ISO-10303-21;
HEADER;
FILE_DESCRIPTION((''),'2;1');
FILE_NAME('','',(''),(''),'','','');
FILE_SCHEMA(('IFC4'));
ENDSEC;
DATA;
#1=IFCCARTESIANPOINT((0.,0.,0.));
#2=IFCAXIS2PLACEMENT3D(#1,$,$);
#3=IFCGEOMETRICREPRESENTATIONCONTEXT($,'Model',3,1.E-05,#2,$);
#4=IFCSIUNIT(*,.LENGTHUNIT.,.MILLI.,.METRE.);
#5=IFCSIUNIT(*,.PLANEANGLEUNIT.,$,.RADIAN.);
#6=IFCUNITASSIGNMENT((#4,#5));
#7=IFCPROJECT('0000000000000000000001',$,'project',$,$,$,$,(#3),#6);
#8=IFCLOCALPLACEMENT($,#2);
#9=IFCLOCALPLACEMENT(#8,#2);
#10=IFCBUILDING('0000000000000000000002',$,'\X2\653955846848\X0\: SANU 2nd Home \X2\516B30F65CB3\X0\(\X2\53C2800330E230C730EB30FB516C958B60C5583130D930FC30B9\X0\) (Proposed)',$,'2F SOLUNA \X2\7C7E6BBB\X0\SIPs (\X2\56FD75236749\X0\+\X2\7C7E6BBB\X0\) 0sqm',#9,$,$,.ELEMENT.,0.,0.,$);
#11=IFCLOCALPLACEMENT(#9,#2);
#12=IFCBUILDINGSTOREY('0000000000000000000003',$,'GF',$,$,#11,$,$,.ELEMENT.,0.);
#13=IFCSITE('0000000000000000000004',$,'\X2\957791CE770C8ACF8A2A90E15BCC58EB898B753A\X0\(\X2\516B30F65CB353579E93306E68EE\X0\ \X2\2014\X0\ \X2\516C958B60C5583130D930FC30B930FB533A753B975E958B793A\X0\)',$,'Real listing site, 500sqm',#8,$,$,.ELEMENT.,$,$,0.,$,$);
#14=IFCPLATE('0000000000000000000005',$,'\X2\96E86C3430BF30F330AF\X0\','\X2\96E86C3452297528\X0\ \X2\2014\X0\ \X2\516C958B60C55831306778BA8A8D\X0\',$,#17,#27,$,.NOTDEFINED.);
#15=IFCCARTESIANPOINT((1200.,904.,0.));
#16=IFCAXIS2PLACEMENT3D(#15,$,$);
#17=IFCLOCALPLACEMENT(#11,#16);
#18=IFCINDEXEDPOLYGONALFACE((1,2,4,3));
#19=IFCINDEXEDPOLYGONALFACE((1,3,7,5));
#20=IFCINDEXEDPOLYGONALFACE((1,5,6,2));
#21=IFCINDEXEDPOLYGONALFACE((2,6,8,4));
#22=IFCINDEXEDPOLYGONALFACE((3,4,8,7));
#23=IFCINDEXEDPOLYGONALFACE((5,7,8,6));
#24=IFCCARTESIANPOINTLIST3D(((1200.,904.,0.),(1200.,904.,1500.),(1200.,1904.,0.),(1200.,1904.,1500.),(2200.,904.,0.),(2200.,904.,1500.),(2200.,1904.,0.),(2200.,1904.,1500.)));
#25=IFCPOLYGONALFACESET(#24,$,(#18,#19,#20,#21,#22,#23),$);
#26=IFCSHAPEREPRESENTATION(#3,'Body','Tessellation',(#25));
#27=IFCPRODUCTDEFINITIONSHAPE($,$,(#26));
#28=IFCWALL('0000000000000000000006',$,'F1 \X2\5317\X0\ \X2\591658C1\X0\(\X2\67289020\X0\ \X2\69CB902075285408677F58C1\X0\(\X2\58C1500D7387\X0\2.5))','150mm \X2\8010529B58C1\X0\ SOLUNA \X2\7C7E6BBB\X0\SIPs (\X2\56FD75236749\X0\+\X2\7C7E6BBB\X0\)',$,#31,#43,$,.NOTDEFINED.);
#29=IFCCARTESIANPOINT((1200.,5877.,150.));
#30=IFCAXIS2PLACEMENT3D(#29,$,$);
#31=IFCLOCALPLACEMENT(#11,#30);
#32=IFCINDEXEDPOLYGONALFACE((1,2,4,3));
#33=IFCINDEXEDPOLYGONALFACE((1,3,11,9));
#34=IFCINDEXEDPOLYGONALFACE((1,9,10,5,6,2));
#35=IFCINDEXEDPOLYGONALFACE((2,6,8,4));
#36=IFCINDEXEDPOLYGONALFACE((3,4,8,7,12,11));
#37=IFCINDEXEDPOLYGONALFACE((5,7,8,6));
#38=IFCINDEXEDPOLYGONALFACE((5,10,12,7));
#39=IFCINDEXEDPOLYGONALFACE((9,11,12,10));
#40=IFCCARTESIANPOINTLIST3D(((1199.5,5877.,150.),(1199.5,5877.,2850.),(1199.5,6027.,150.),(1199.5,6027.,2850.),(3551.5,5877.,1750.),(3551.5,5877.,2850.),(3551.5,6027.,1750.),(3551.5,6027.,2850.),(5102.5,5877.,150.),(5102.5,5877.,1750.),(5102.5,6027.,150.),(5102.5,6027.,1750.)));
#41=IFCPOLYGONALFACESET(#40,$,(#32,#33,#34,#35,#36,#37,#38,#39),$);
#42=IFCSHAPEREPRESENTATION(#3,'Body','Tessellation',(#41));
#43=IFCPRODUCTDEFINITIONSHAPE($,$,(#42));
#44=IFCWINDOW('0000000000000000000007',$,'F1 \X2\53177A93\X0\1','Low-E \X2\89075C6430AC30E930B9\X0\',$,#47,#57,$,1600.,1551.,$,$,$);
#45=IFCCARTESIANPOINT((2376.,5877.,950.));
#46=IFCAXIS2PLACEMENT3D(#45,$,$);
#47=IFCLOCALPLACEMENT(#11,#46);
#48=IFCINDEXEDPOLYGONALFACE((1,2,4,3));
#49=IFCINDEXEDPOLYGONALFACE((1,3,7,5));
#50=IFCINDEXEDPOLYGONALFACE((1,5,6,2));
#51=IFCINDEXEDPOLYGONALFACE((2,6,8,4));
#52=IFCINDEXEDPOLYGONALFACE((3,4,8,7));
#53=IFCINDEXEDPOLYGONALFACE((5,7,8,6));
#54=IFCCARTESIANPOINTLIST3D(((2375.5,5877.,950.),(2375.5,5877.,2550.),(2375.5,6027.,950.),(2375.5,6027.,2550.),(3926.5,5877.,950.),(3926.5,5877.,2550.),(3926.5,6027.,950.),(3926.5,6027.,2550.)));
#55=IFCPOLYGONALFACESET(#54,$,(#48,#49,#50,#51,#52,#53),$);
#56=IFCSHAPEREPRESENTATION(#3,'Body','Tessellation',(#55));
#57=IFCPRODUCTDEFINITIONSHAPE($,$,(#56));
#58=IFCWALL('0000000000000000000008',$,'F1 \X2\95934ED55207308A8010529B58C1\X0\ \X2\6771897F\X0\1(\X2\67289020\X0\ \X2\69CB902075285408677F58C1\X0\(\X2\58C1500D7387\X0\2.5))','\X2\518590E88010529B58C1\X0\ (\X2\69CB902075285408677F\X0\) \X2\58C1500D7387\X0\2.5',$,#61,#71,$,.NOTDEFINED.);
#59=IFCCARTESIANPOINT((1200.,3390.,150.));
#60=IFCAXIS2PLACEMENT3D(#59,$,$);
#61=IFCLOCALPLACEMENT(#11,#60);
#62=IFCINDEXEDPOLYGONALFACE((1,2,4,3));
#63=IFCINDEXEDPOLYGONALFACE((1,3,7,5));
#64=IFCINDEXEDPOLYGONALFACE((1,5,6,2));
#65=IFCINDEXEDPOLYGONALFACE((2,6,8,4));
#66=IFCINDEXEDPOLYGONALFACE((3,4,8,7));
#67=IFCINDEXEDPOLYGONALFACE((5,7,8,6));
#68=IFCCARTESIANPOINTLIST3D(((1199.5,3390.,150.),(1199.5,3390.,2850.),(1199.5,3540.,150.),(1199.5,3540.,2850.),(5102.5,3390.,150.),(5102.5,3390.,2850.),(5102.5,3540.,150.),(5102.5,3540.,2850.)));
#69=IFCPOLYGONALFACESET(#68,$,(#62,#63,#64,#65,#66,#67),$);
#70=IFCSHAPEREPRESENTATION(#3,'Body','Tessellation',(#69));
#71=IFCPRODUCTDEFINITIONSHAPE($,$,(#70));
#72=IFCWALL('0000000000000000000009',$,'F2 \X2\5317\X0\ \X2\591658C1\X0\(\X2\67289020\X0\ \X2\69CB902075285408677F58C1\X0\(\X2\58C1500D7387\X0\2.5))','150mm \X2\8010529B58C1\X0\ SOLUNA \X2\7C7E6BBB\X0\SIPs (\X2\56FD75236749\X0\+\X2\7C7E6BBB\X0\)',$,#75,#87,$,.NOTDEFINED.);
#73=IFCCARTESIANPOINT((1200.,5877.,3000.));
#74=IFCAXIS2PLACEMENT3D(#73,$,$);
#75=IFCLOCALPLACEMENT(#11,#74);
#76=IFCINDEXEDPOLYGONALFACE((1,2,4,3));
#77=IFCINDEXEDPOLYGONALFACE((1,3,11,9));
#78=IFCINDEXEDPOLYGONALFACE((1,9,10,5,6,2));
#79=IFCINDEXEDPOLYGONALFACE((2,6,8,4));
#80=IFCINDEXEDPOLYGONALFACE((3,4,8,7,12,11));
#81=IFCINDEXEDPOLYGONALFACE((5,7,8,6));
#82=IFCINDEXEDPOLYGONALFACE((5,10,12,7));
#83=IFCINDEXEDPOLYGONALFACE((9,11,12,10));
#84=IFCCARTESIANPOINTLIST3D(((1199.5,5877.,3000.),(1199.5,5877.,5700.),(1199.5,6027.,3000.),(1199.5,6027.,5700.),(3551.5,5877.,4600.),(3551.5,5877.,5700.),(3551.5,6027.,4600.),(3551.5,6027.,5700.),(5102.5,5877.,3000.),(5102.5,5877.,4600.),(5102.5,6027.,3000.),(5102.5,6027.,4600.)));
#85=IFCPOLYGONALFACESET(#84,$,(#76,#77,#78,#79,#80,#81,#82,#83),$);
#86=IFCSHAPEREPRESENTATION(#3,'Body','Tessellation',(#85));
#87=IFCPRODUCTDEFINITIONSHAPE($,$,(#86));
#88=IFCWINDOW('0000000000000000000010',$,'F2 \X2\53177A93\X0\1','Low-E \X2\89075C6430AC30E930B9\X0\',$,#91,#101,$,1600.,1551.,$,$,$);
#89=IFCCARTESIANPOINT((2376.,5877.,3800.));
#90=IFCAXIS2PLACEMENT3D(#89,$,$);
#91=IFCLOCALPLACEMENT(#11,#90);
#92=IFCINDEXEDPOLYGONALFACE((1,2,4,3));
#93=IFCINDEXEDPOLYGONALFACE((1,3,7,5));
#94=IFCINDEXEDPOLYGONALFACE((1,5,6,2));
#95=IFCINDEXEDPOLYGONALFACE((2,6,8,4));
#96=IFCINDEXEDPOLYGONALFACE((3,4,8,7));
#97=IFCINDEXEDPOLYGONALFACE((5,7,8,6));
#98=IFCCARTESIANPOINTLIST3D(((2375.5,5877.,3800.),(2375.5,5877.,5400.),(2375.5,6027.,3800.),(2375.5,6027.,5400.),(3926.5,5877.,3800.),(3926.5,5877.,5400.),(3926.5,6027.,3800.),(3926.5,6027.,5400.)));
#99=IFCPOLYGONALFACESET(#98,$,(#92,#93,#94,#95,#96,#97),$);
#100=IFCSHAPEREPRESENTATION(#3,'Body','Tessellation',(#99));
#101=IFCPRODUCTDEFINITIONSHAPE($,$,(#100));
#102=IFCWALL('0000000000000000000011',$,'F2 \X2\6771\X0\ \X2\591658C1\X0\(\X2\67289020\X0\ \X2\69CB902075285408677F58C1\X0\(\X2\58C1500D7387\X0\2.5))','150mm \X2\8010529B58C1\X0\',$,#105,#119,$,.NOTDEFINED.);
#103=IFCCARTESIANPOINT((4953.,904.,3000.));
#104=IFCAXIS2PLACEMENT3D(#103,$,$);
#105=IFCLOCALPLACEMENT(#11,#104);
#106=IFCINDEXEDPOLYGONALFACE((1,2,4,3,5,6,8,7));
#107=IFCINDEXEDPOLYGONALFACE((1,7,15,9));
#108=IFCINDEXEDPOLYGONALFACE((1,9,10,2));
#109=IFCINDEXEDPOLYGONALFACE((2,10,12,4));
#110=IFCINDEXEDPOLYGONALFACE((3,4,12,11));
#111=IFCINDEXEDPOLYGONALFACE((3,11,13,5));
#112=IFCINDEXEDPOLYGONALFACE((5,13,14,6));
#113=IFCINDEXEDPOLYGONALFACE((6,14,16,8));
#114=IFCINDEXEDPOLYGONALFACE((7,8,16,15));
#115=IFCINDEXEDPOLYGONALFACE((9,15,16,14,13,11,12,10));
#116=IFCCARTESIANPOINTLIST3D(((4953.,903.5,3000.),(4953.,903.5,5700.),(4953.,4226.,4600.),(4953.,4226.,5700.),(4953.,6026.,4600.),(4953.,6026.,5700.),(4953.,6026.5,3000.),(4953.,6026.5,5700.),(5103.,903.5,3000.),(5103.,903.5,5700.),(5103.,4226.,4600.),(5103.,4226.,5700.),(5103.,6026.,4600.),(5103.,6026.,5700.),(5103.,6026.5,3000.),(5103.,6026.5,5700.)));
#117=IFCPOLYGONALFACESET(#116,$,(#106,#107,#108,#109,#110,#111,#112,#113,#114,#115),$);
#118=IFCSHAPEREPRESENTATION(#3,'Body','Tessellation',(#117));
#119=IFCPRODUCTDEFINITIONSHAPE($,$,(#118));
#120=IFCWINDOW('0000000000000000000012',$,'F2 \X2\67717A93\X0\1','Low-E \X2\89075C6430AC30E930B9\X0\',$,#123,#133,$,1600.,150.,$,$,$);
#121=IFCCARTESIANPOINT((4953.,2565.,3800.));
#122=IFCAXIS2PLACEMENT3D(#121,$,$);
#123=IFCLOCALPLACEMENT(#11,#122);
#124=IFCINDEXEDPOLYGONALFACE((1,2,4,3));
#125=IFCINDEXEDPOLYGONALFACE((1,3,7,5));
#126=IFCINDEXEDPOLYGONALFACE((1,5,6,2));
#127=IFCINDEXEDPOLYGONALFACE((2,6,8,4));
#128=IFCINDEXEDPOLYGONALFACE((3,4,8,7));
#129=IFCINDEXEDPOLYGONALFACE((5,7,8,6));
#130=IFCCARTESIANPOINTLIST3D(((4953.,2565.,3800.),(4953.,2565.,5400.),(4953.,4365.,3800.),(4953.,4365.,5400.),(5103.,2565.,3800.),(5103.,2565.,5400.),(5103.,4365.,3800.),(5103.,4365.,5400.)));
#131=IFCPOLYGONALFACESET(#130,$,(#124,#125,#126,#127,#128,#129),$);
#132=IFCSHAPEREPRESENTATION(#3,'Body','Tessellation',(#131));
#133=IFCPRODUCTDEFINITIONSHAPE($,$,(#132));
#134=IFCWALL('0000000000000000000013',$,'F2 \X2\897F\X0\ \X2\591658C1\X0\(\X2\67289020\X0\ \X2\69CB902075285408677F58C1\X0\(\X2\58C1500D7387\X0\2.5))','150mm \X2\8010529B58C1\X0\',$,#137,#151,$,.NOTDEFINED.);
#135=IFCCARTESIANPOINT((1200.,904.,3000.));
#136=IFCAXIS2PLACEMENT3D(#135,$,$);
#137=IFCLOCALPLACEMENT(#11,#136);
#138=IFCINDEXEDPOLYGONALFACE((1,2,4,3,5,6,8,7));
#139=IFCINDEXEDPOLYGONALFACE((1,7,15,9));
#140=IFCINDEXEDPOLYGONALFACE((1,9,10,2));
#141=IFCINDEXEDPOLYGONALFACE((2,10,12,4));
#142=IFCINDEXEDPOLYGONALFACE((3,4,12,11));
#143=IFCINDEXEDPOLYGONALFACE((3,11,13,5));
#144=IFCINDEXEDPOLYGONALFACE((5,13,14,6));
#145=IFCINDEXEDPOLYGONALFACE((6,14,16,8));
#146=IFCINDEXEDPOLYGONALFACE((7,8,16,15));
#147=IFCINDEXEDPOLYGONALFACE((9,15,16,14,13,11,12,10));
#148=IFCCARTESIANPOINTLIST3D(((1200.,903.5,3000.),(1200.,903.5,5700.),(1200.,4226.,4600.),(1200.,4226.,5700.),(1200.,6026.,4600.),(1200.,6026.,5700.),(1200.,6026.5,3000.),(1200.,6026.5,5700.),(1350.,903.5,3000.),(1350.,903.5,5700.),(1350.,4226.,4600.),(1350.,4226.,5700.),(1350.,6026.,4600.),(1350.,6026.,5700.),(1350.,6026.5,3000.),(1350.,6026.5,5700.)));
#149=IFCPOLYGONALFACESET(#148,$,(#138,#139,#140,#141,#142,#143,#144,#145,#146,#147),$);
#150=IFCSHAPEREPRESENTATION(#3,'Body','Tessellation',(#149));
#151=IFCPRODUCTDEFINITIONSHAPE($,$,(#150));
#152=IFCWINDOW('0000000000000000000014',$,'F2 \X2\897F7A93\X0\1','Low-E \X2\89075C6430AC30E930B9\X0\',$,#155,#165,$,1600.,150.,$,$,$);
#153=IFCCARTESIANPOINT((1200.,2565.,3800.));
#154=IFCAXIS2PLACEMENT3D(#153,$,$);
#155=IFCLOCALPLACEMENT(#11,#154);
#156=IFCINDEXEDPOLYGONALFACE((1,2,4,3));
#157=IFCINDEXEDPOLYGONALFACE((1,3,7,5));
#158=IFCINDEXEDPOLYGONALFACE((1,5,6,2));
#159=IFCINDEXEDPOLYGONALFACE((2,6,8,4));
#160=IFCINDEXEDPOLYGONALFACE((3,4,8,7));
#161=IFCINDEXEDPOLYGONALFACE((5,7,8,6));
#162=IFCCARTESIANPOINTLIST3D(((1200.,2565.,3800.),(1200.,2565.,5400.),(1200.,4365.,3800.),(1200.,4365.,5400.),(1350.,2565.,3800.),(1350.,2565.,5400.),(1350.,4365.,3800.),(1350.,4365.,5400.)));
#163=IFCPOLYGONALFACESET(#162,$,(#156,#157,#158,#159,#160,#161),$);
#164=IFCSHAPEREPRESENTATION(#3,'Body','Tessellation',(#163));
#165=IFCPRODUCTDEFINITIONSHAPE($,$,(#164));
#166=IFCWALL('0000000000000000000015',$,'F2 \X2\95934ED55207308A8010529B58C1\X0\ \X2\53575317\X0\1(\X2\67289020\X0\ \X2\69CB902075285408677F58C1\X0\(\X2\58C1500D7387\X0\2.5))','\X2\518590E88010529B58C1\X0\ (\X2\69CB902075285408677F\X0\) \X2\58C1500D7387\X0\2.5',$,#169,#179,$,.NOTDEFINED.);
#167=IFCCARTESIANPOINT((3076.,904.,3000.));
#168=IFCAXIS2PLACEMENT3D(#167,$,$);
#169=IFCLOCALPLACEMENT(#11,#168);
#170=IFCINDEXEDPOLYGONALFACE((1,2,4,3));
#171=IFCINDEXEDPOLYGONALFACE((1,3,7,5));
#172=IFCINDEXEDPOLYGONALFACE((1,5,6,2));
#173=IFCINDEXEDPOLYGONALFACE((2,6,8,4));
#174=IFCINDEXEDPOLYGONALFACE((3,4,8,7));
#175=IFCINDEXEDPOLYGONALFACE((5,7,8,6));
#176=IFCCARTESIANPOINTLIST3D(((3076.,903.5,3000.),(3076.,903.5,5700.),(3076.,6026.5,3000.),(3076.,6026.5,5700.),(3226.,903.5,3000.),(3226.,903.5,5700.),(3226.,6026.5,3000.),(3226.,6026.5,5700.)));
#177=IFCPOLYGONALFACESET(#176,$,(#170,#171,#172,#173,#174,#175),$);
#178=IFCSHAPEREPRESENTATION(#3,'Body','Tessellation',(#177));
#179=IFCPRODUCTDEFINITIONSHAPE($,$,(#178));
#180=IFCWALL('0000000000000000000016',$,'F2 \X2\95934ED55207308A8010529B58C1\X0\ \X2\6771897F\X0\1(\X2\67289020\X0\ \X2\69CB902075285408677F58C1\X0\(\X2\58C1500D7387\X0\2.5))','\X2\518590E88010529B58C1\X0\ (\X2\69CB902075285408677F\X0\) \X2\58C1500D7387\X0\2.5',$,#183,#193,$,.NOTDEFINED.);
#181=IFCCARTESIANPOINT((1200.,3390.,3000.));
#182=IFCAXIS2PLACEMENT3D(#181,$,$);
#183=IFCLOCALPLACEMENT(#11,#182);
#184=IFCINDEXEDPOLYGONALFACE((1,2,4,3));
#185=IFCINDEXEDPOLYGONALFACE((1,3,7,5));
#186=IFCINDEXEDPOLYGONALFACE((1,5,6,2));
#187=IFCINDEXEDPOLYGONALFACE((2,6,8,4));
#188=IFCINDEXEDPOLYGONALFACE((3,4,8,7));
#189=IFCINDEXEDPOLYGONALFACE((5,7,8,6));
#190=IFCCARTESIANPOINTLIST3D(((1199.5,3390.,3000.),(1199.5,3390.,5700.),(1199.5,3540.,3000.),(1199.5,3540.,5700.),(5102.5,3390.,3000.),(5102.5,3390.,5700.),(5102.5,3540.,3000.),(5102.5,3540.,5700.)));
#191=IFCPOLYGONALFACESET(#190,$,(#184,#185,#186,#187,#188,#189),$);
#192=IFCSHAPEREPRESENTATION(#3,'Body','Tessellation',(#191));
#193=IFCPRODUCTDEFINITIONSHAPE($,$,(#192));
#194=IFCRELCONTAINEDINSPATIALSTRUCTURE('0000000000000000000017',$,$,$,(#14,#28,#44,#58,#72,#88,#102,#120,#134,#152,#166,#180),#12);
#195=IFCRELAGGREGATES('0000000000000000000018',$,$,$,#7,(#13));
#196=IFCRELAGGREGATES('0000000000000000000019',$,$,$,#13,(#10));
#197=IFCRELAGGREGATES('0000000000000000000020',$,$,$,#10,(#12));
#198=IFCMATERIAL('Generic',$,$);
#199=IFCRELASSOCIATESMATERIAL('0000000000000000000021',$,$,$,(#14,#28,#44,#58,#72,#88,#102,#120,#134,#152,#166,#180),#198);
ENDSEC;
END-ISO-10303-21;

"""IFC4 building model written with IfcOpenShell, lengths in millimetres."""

from ifc_helpers import new_model, si_unit, frame, frame_2d, origin, place, context, project, spatial, rectangle, extrude, material, element, fill, save


model = new_model("IFC4")

# Units and contexts
model_context = context("Model", 3, precision=1e-05, world=origin())
ifc_project = project(units=[si_unit("LENGTHUNIT", "METRE", prefix="MILLI"), si_unit("PLANEANGLEUNIT", "RADIAN")], contexts=[model_context])

# Site, building, storey
site_placement = place(None, origin())
site = spatial("IfcSite", under=ifc_project, at=site_placement, Name="長野県諏訪郡富士見町(八ヶ岳南麓の森 — 公開情報ベース・区画非開示)", ObjectType="Real listing site, 500sqm", CompositionType="ELEMENT", RefElevation=0.0)
building_placement = place(site_placement, origin())
building = spatial("IfcBuilding", under=site, at=building_placement, Name="改善案: SANU 2nd Home 八ヶ岳(参考モデル・公開情報ベース) (Proposed)", ObjectType="2F SOLUNA 籾殻SIPs (国産杉+籾殻) 0sqm", CompositionType="ELEMENT", ElevationOfRefHeight=0.0, ElevationOfTerrain=0.0)
storey_placement = place(building_placement, origin())
storey = spatial("IfcBuildingStorey", under=building, at=storey_placement, Name="GF", CompositionType="ELEMENT", Elevation=0.0)

# Plate
ifc_material_1 = material(Name="Generic")
plate_placement = place(storey_placement, frame((1200.0, 904.0, 0.0)))
element("IfcPlate", 1, at=plate_placement, inside=storey, material=ifc_material_1, Name="雨水タンク", Description="雨水利用 — 公開情報で確認", PredefinedType="NOTDEFINED", context=model_context, shape_type="SweptSolid", body=[
    extrude(rectangle(XDim=1000.0, YDim=1000.0, at=frame_2d((500.0, 500.0))), frame((1200.0, 904.0, 0.0)), (0.0, 0.0, 1.0), 1500.0),
])

# Wall, opening, window
wall_1_placement = place(storey_placement, frame((1200.0, 5877.0, 150.0)))
wall_1 = element("IfcWall", 2, at=wall_1_placement, inside=storey, material=ifc_material_1, Name="F1 北 外壁(木造 構造用合板壁(壁倍率2.5))", Description="150mm 耐力壁 SOLUNA 籾殻SIPs (国産杉+籾殻)", PredefinedType="NOTDEFINED", context=model_context, shape_type="SweptSolid", body=[
    extrude(rectangle(XDim=3903.0, YDim=150.0, at=frame_2d((1951.0, 75.0))), frame((1200.0, 5877.0, 150.0)), (0.0, 0.0, 1.0), 2700.0),
])
opening_1_placement = place(storey_placement, frame((2376.0, 5877.0, 950.0)))
opening_1 = element("IfcOpeningElement", 3, at=opening_1_placement, cuts=wall_1, PredefinedType="NOTDEFINED", context=model_context, shape_type="SweptSolid", body=[
    extrude(rectangle(XDim=1551.0, YDim=150.0, at=frame_2d((775.0, 75.0))), frame((2376.0, 5877.0, 950.0)), (0.0, 0.0, 1.0), 1600.0),
])
window_1_placement = place(storey_placement, frame((2376.0, 5877.0, 950.0)))
window_1 = element("IfcWindow", 4, at=window_1_placement, inside=storey, material=ifc_material_1, Name="F1 北窓1", Description="Low-E 複層ガラス", OverallHeight=1600.0, OverallWidth=1551.0, context=model_context, shape_type="SweptSolid", body=[
    extrude(rectangle(XDim=1551.0, YDim=150.0, at=frame_2d((775.0, 75.0))), frame((2376.0, 5877.0, 950.0)), (0.0, 0.0, 1.0), 1600.0),
])
fill(opening_1, window_1)

# Wall
wall_2_placement = place(storey_placement, frame((1200.0, 3390.0, 150.0)))
element("IfcWall", 5, at=wall_2_placement, inside=storey, material=ifc_material_1, Name="F1 間仕切り耐力壁 東西1(木造 構造用合板壁(壁倍率2.5))", Description="内部耐力壁 (構造用合板) 壁倍率2.5", PredefinedType="NOTDEFINED", context=model_context, shape_type="SweptSolid", body=[
    extrude(rectangle(XDim=3903.0, YDim=150.0, at=frame_2d((1951.0, 75.0))), frame((1200.0, 3390.0, 150.0)), (0.0, 0.0, 1.0), 2700.0),
])

# Walls, openings, windows
wall_3_placement = place(storey_placement, frame((1200.0, 5877.0, 3000.0)))
wall_3 = element("IfcWall", 6, at=wall_3_placement, inside=storey, material=ifc_material_1, Name="F2 北 外壁(木造 構造用合板壁(壁倍率2.5))", Description="150mm 耐力壁 SOLUNA 籾殻SIPs (国産杉+籾殻)", PredefinedType="NOTDEFINED", context=model_context, shape_type="SweptSolid", body=[
    extrude(rectangle(XDim=3903.0, YDim=150.0, at=frame_2d((1951.0, 75.0))), frame((1200.0, 5877.0, 3000.0)), (0.0, 0.0, 1.0), 2700.0),
])
opening_2_placement = place(storey_placement, frame((2376.0, 5877.0, 3800.0)))
opening_2 = element("IfcOpeningElement", 7, at=opening_2_placement, cuts=wall_3, PredefinedType="NOTDEFINED", context=model_context, shape_type="SweptSolid", body=[
    extrude(rectangle(XDim=1551.0, YDim=150.0, at=frame_2d((775.0, 75.0))), frame((2376.0, 5877.0, 3800.0)), (0.0, 0.0, 1.0), 1600.0),
])
window_2_placement = place(storey_placement, frame((2376.0, 5877.0, 3800.0)))
window_2 = element("IfcWindow", 8, at=window_2_placement, inside=storey, material=ifc_material_1, Name="F2 北窓1", Description="Low-E 複層ガラス", OverallHeight=1600.0, OverallWidth=1551.0, context=model_context, shape_type="SweptSolid", body=[
    extrude(rectangle(XDim=1551.0, YDim=150.0, at=frame_2d((775.0, 75.0))), frame((2376.0, 5877.0, 3800.0)), (0.0, 0.0, 1.0), 1600.0),
])
fill(opening_2, window_2)
wall_4_placement = place(storey_placement, frame((4953.0, 904.0, 3000.0)))
wall_4 = element("IfcWall", 9, at=wall_4_placement, inside=storey, material=ifc_material_1, Name="F2 東 外壁(木造 構造用合板壁(壁倍率2.5))", Description="150mm 耐力壁", PredefinedType="NOTDEFINED", context=model_context, shape_type="SweptSolid", body=[
    extrude(rectangle(XDim=150.0, YDim=5123.0, at=frame_2d((75.0, 2561.0))), frame((4953.0, 904.0, 3000.0)), (0.0, 0.0, 1.0), 2700.0),
])
opening_3_placement = place(storey_placement, frame((4953.0, 2565.0, 3800.0)))
opening_3 = element("IfcOpeningElement", 10, at=opening_3_placement, cuts=wall_4, PredefinedType="NOTDEFINED", context=model_context, shape_type="SweptSolid", body=[
    extrude(rectangle(XDim=150.0, YDim=1800.0, at=frame_2d((75.0, 900.0))), frame((4953.0, 2565.0, 3800.0)), (0.0, 0.0, 1.0), 1600.0),
])
window_3_placement = place(storey_placement, frame((4953.0, 2565.0, 3800.0)))
window_3 = element("IfcWindow", 11, at=window_3_placement, inside=storey, material=ifc_material_1, Name="F2 東窓1", Description="Low-E 複層ガラス", OverallHeight=1600.0, OverallWidth=150.0, context=model_context, shape_type="SweptSolid", body=[
    extrude(rectangle(XDim=150.0, YDim=1800.0, at=frame_2d((75.0, 900.0))), frame((4953.0, 2565.0, 3800.0)), (0.0, 0.0, 1.0), 1600.0),
])
fill(opening_3, window_3)
wall_5_placement = place(storey_placement, frame((1200.0, 904.0, 3000.0)))
wall_5 = element("IfcWall", 12, at=wall_5_placement, inside=storey, material=ifc_material_1, Name="F2 西 外壁(木造 構造用合板壁(壁倍率2.5))", Description="150mm 耐力壁", PredefinedType="NOTDEFINED", context=model_context, shape_type="SweptSolid", body=[
    extrude(rectangle(XDim=150.0, YDim=5123.0, at=frame_2d((75.0, 2561.0))), frame((1200.0, 904.0, 3000.0)), (0.0, 0.0, 1.0), 2700.0),
])
opening_4_placement = place(storey_placement, frame((1200.0, 2565.0, 3800.0)))
opening_4 = element("IfcOpeningElement", 13, at=opening_4_placement, cuts=wall_5, PredefinedType="NOTDEFINED", context=model_context, shape_type="SweptSolid", body=[
    extrude(rectangle(XDim=150.0, YDim=1800.0, at=frame_2d((75.0, 900.0))), frame((1200.0, 2565.0, 3800.0)), (0.0, 0.0, 1.0), 1600.0),
])
window_4_placement = place(storey_placement, frame((1200.0, 2565.0, 3800.0)))
window_4 = element("IfcWindow", 14, at=window_4_placement, inside=storey, material=ifc_material_1, Name="F2 西窓1", Description="Low-E 複層ガラス", OverallHeight=1600.0, OverallWidth=150.0, context=model_context, shape_type="SweptSolid", body=[
    extrude(rectangle(XDim=150.0, YDim=1800.0, at=frame_2d((75.0, 900.0))), frame((1200.0, 2565.0, 3800.0)), (0.0, 0.0, 1.0), 1600.0),
])
fill(opening_4, window_4)

# Walls
wall_6_placement = place(storey_placement, frame((3076.0, 904.0, 3000.0)))
element("IfcWall", 15, at=wall_6_placement, inside=storey, material=ifc_material_1, Name="F2 間仕切り耐力壁 南北1(木造 構造用合板壁(壁倍率2.5))", Description="内部耐力壁 (構造用合板) 壁倍率2.5", PredefinedType="NOTDEFINED", context=model_context, shape_type="SweptSolid", body=[
    extrude(rectangle(XDim=150.0, YDim=5123.0, at=frame_2d((75.0, 2561.0))), frame((3076.0, 904.0, 3000.0)), (0.0, 0.0, 1.0), 2700.0),
])
wall_7_placement = place(storey_placement, frame((1200.0, 3390.0, 3000.0)))
element("IfcWall", 16, at=wall_7_placement, inside=storey, material=ifc_material_1, Name="F2 間仕切り耐力壁 東西1(木造 構造用合板壁(壁倍率2.5))", Description="内部耐力壁 (構造用合板) 壁倍率2.5", PredefinedType="NOTDEFINED", context=model_context, shape_type="SweptSolid", body=[
    extrude(rectangle(XDim=3903.0, YDim=150.0, at=frame_2d((1951.0, 75.0))), frame((1200.0, 3390.0, 3000.0)), (0.0, 0.0, 1.0), 2700.0),
])

save(model, "model.ifc")
